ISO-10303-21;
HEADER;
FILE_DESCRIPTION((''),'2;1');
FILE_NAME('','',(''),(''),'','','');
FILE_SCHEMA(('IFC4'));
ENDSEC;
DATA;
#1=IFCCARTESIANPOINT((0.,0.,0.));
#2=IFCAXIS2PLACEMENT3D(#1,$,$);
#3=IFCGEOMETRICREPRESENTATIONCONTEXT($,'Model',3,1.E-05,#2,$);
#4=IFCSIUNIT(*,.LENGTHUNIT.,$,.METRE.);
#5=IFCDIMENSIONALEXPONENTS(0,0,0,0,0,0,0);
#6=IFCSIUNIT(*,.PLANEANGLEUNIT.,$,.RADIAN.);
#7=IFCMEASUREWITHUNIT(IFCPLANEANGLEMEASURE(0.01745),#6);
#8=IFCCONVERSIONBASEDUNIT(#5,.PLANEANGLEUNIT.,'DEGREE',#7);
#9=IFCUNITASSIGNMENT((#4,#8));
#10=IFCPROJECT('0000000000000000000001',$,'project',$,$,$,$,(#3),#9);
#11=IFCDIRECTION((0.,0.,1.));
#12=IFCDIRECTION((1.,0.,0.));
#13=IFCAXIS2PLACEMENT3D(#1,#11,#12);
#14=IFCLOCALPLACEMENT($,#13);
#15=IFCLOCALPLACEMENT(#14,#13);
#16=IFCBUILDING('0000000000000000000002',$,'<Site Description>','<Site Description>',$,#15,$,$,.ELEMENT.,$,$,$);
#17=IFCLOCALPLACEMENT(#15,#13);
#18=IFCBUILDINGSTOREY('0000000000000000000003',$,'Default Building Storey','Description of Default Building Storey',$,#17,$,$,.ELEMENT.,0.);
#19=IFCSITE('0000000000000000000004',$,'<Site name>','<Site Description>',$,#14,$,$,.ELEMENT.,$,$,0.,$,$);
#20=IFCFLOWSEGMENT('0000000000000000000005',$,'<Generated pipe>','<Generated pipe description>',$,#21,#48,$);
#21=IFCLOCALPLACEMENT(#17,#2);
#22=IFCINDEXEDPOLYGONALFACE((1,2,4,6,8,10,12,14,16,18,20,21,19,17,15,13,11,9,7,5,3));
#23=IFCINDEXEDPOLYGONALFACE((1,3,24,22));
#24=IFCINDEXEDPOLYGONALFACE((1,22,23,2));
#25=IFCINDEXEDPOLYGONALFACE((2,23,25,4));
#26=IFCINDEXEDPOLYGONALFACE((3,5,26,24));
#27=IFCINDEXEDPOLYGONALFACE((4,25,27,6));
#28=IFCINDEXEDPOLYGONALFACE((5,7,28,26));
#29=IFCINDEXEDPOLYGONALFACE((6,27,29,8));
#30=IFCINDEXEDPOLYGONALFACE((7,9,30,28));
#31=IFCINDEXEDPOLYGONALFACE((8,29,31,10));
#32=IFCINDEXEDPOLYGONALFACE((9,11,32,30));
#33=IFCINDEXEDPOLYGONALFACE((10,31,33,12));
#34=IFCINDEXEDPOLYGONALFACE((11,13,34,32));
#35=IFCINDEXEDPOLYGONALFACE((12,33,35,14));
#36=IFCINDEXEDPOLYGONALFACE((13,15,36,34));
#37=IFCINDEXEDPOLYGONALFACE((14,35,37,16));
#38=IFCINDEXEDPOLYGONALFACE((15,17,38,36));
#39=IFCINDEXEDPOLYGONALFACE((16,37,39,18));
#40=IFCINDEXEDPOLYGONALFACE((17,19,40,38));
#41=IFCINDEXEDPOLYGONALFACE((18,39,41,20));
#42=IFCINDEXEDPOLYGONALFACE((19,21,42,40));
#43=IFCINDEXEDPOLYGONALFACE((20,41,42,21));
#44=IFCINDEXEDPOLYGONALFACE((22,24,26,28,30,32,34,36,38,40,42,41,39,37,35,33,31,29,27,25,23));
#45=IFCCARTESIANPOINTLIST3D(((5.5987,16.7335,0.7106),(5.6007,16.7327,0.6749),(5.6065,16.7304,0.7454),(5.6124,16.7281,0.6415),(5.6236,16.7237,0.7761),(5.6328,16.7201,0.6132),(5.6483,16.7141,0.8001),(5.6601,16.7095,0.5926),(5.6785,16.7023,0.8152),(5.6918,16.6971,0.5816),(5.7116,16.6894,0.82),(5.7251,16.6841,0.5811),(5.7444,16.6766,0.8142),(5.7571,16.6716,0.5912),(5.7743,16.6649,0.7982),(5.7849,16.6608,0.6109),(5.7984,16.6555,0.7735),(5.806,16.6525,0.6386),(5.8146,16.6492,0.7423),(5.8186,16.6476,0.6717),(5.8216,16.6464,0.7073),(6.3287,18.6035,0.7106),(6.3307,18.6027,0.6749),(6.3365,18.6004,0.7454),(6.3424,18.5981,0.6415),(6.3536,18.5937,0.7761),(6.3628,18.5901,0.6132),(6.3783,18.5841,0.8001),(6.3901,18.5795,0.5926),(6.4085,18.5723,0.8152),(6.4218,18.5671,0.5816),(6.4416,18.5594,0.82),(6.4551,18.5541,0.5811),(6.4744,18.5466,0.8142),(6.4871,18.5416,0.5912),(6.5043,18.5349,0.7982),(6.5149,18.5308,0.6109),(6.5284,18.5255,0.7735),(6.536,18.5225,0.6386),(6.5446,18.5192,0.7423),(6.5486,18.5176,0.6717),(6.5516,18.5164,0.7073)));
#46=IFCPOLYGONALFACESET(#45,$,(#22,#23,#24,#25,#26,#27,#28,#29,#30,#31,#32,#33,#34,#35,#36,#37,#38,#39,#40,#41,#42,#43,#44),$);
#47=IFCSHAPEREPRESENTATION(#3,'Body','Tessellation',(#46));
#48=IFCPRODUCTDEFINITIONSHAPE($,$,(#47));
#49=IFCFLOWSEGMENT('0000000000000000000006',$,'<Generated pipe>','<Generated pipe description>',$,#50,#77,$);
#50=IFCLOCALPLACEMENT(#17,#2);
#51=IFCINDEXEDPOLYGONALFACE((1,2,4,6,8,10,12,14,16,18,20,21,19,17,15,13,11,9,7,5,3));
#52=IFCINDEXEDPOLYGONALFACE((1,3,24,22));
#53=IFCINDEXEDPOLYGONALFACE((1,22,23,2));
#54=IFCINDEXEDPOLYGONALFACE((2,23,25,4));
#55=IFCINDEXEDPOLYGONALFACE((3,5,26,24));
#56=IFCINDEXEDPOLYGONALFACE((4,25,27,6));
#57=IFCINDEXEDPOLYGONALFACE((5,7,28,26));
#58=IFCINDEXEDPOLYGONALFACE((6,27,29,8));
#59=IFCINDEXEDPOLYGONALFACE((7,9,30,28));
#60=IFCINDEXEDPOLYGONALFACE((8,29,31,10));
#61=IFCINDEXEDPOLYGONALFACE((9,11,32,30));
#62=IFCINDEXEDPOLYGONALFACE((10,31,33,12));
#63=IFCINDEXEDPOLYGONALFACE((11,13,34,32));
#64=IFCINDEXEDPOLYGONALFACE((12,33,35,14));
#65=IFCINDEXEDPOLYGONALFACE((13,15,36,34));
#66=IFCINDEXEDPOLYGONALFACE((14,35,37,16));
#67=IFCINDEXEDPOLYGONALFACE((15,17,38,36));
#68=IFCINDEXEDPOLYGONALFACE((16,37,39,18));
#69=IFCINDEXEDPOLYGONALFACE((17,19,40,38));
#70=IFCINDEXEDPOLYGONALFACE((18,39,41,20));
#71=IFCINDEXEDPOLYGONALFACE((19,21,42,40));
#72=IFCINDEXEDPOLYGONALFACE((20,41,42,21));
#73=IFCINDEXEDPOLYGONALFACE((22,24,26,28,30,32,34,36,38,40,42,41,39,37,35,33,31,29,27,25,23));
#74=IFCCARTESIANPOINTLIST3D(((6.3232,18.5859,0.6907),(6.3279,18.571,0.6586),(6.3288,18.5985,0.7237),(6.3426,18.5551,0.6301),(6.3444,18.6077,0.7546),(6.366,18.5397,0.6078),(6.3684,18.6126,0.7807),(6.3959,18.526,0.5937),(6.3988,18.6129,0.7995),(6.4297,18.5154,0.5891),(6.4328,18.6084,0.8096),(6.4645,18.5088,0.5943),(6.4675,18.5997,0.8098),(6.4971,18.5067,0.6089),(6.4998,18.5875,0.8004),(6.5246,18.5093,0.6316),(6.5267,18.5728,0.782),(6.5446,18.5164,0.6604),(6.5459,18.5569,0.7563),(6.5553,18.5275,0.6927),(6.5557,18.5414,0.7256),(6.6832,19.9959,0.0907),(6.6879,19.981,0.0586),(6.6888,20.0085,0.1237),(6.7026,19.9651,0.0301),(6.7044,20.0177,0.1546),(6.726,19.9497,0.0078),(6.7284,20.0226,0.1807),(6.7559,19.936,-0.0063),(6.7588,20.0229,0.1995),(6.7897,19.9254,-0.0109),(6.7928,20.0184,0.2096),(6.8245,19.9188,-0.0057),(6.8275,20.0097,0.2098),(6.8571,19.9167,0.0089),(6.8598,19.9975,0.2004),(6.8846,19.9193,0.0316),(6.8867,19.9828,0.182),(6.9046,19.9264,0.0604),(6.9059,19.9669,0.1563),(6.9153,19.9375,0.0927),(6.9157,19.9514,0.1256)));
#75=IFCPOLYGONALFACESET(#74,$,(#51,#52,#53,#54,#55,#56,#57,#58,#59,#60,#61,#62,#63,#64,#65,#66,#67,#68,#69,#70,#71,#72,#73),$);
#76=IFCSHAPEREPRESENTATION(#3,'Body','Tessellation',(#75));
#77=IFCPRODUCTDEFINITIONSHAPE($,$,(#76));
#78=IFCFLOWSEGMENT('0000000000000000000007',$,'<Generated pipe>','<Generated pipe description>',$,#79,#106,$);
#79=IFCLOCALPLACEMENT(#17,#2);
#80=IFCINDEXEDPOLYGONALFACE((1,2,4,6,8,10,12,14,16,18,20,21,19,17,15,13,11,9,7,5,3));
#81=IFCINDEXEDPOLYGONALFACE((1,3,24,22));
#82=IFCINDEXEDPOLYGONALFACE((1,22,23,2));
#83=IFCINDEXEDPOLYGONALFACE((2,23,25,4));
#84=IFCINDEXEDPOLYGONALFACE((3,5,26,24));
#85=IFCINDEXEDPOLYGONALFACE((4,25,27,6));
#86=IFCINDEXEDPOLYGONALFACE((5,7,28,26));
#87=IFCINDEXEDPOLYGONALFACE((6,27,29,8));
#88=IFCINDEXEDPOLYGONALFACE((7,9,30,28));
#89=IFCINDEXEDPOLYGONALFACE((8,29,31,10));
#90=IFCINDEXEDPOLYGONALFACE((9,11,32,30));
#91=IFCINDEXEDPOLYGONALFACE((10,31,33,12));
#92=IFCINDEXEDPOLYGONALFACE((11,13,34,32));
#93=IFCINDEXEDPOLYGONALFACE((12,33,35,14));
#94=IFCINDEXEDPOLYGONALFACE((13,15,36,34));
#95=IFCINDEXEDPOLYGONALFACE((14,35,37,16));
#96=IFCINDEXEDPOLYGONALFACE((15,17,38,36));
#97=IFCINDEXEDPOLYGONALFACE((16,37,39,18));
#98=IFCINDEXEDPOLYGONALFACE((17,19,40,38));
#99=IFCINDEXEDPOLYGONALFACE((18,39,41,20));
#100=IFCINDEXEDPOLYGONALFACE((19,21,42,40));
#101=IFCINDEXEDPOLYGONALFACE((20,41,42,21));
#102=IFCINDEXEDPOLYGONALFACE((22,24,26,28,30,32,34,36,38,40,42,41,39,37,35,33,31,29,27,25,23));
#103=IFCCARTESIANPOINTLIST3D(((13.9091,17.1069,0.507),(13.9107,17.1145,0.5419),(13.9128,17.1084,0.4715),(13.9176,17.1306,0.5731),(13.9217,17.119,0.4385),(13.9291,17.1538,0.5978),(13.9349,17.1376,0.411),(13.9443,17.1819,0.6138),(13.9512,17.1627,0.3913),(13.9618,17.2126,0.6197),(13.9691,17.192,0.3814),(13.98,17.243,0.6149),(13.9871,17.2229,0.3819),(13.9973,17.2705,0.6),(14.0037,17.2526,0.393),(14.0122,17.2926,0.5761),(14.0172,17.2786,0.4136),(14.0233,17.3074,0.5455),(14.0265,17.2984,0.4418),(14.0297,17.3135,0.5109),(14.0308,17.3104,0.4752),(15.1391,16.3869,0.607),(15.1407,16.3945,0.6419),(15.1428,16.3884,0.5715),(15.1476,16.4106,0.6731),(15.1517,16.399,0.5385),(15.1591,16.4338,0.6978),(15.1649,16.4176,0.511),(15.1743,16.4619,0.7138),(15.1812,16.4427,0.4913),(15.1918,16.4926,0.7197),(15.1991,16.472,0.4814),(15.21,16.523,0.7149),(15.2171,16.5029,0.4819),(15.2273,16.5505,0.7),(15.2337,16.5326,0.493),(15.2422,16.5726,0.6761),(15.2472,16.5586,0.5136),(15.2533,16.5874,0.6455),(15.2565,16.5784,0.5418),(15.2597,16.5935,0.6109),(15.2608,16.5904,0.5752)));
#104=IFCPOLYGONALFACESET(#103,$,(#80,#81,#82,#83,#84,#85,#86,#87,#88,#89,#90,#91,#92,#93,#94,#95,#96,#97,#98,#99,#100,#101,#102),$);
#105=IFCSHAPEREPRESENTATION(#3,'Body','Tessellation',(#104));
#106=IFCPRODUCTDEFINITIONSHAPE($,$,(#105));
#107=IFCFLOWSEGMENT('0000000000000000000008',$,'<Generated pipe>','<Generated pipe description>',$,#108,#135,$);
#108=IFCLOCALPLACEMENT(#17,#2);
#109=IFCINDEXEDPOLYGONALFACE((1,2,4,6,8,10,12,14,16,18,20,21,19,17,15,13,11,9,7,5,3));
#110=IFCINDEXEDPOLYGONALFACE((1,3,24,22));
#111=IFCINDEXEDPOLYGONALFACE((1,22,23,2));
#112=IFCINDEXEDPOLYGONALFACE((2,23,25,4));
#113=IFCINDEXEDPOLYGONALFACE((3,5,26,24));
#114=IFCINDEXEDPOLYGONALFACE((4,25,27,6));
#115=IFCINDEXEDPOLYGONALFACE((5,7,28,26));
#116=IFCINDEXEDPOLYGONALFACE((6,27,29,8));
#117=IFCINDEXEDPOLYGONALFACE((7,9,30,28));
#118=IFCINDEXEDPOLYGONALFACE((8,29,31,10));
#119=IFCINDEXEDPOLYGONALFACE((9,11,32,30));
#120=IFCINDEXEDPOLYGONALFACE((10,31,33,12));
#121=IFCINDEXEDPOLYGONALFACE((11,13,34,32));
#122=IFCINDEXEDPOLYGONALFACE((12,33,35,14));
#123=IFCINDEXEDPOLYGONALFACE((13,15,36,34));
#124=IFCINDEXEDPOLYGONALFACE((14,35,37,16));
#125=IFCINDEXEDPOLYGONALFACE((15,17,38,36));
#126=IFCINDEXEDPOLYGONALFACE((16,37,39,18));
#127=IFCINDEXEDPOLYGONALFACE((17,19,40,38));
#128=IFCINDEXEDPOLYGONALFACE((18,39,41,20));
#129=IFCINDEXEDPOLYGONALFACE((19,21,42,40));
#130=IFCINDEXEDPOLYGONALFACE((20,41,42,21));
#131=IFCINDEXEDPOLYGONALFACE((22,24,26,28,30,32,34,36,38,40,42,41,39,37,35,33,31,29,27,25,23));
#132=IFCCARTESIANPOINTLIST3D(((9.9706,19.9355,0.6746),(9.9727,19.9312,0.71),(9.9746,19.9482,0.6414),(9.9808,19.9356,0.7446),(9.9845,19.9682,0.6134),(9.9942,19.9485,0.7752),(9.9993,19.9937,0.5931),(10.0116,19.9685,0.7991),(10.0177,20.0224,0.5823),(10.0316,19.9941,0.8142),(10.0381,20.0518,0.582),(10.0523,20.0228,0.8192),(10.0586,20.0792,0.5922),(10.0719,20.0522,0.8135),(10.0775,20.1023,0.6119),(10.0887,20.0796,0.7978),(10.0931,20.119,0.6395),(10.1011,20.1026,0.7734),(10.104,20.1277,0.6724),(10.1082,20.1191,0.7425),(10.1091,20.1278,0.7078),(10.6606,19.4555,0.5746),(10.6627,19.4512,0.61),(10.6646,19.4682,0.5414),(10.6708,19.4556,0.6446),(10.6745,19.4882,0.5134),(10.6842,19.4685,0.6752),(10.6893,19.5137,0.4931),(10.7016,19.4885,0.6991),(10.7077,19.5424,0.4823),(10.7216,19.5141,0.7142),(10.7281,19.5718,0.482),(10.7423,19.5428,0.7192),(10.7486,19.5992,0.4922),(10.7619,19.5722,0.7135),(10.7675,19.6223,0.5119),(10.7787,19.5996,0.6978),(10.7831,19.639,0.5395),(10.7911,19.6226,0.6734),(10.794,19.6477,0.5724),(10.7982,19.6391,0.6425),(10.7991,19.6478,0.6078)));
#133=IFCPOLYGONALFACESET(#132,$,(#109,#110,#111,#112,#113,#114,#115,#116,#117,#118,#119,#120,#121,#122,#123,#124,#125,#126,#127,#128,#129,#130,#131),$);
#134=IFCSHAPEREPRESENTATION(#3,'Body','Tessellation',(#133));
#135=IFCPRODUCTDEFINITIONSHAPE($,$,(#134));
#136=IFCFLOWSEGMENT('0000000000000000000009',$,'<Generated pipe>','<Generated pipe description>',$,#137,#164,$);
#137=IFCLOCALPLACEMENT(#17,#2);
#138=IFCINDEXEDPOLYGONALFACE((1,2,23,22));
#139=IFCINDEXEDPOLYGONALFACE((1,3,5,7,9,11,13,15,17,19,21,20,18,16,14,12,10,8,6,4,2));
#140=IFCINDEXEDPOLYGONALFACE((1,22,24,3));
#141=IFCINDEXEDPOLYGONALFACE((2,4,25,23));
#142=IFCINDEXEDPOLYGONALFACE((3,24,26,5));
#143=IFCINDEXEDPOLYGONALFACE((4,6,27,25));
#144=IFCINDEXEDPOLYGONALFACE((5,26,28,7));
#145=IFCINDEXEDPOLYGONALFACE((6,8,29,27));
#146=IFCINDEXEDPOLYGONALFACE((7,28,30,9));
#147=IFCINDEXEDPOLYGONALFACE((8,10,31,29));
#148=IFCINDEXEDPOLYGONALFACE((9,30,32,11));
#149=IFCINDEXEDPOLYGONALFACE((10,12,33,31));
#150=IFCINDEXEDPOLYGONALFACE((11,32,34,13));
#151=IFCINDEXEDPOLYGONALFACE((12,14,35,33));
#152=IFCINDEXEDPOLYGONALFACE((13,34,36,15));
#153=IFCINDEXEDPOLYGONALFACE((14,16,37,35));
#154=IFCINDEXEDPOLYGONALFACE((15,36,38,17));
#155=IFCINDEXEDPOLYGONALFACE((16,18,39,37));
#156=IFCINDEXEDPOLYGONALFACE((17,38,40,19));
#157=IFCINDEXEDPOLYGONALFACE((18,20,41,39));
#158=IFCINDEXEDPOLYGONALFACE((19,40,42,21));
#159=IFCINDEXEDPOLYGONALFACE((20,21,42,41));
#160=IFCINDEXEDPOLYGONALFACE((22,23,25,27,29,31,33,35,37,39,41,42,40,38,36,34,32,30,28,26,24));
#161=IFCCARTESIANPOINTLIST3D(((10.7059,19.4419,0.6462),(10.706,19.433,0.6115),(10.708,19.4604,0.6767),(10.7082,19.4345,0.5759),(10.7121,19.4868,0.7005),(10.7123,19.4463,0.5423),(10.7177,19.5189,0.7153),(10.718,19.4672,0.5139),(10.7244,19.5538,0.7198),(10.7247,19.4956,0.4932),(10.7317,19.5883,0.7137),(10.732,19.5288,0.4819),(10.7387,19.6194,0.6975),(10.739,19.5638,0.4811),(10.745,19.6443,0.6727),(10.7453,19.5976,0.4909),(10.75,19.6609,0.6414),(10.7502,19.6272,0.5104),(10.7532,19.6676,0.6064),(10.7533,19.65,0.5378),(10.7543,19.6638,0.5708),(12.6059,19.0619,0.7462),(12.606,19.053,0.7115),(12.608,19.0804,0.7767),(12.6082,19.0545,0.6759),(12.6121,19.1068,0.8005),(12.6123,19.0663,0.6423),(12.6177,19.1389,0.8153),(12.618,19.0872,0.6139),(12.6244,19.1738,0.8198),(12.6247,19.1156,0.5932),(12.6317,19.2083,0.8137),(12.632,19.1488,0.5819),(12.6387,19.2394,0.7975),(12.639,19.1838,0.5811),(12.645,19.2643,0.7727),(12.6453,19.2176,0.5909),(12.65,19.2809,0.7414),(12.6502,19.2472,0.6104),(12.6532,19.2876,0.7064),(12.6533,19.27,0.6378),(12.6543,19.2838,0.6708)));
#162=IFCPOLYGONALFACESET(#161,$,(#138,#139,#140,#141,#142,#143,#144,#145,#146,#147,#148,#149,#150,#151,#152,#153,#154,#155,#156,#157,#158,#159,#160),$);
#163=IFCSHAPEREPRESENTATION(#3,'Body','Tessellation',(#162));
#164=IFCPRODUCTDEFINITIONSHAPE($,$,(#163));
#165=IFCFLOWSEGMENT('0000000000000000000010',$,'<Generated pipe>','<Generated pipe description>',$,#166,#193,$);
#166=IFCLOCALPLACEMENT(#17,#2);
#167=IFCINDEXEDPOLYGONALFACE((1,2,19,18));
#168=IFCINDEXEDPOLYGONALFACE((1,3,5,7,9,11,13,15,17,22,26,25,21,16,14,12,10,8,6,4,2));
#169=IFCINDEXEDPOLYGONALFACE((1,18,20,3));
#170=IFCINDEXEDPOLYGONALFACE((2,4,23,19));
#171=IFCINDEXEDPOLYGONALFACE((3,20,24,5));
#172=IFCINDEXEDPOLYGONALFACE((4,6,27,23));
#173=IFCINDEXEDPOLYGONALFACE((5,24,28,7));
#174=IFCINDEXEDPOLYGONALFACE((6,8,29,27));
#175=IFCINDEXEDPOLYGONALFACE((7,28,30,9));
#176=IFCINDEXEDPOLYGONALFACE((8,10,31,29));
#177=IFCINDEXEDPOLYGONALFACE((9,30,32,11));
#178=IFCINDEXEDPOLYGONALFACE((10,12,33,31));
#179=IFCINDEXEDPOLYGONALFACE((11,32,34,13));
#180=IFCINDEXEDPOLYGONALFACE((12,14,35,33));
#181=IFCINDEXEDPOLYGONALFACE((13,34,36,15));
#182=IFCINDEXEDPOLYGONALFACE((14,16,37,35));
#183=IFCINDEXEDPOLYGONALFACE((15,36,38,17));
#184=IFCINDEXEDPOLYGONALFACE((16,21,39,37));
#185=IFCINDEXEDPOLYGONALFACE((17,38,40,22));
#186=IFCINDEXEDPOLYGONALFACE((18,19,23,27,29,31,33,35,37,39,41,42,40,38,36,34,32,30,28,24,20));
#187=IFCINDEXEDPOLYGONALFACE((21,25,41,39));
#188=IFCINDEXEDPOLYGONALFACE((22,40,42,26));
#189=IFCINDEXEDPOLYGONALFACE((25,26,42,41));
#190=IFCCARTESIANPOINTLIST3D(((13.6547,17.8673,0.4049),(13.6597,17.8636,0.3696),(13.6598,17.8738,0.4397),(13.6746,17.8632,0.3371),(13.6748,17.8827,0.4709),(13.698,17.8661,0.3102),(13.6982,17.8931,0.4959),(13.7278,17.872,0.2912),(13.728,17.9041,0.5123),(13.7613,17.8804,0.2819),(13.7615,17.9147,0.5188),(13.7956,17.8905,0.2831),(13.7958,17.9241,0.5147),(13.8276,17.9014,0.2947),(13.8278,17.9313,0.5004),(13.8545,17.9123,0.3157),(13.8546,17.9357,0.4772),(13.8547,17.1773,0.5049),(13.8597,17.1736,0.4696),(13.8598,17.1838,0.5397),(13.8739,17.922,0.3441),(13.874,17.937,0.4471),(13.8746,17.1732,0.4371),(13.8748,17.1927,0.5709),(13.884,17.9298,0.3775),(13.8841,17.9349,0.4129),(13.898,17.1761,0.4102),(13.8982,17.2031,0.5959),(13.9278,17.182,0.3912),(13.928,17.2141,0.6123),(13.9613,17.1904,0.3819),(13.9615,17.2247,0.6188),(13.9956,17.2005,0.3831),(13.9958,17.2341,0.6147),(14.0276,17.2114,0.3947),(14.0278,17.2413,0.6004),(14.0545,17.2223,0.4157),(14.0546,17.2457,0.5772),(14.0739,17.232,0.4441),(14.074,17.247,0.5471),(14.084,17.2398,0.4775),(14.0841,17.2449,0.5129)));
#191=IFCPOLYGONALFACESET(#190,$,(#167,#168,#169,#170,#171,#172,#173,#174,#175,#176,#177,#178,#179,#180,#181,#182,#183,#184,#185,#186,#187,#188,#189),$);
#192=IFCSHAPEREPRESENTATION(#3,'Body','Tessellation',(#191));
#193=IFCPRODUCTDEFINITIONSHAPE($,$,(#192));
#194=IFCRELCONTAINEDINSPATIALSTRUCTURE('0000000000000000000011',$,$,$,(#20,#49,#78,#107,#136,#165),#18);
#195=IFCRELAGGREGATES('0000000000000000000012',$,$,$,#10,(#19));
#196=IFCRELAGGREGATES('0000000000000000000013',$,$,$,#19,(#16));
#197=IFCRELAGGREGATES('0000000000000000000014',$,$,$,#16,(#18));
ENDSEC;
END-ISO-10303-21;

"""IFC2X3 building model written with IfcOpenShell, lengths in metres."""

from ifc_helpers import new_model, entity, si_unit, converted_unit, frame, origin, origin_with_axes, origin_2d_with_axis, place, context, project, spatial, circle, extrude, element, save


model = new_model("IFC2X3")

# Units and contexts
model_context = context("Model", 3, precision=1e-05, world=origin())
ifc_project = project(units=[si_unit("LENGTHUNIT", "METRE"), converted_unit("PLANEANGLEUNIT", "DEGREE", entity("IfcPlaneAngleMeasure", 0.01745), si_unit("PLANEANGLEUNIT", "RADIAN"), dimensions=[0, 0, 0, 0, 0, 0, 0])], contexts=[model_context])

# Site, building, storey
site_placement = place(None, origin_with_axes())
site = spatial("IfcSite", under=ifc_project, at=site_placement, Name="<Site name>", Description="<Site Description>", CompositionType="ELEMENT", RefElevation=0.0)
building_placement = place(site_placement, origin_with_axes())
building = spatial("IfcBuilding", under=site, at=building_placement, Name="<Site Description>", Description="<Site Description>", CompositionType="ELEMENT")
storey_placement = place(building_placement, origin_with_axes())
storey = spatial("IfcBuildingStorey", under=building, at=storey_placement, Name="Default Building Storey", Description="Description of Default Building Storey", CompositionType="ELEMENT", Elevation=0.0)

# Flow segments
flow_segment_1_placement = place(storey_placement, frame((5.71, 16.69, 0.7), z_axis=(0.363648, 0.931536, 0.0), x_axis=(0.535422, -0.209015, 0.818313)))
element("IfcFlowSegment", 1, at=flow_segment_1_placement, inside=storey, Name="<Generated pipe>", Description="<Generated pipe description>", context=model_context, shape_type="SweptSolid", body=[
    extrude(circle(Radius=0.12, at=origin_2d_with_axis()), origin_with_axes(), (0.0, 0.0, 1.0), 2.0074),
])
flow_segment_2_placement = place(storey_placement, frame((6.44, 18.56, 0.7), z_axis=(0.228706, 0.895766, -0.381177), x_axis=(0.497959, 0.228807, 0.836471)))
element("IfcFlowSegment", 2, at=flow_segment_2_placement, inside=storey, Name="<Generated pipe>", Description="<Generated pipe description>", context=model_context, shape_type="SweptSolid", body=[
    extrude(circle(Radius=0.12, at=origin_2d_with_axis()), origin_with_axes(), (0.0, 0.0, 1.0), 1.5741),
])
flow_segment_3_placement = place(storey_placement, frame((13.97, 17.21, 0.5), z_axis=(0.860898, -0.50394, 0.069992), x_axis=(0.444285, 0.811658, 0.379239)))
element("IfcFlowSegment", 3, at=flow_segment_3_placement, inside=storey, Name="<Generated pipe>", Description="<Generated pipe description>", context=model_context, shape_type="SweptSolid", body=[
    extrude(circle(Radius=0.12, at=origin_2d_with_axis()), origin_with_axes(), (0.0, 0.0, 1.0), 1.4287),
])
flow_segment_4_placement = place(storey_placement, frame((10.04, 20.03, 0.7), z_axis=(0.815156, -0.567065, -0.118139), x_axis=(0.4057, 0.413362, 0.815193)))
element("IfcFlowSegment", 4, at=flow_segment_4_placement, inside=storey, Name="<Generated pipe>", Description="<Generated pipe description>", context=model_context, shape_type="SweptSolid", body=[
    extrude(circle(Radius=0.12, at=origin_2d_with_axis()), origin_with_axes(), (0.0, 0.0, 1.0), 0.8465),
])
flow_segment_5_placement = place(storey_placement, frame((10.73, 19.55, 0.6), z_axis=(0.979277, -0.195855, 0.051541), x_axis=(0.013884, 0.318817, 0.947715)))
element("IfcFlowSegment", 5, at=flow_segment_5_placement, inside=storey, Name="<Generated pipe>", Description="<Generated pipe description>", context=model_context, shape_type="SweptSolid", body=[
    extrude(circle(Radius=0.12, at=origin_2d_with_axis()), origin_with_axes(), (0.0, 0.0, 1.0), 1.9402),
])
flow_segment_6_placement = place(storey_placement, frame((13.77, 17.9, 0.4), z_axis=(0.275738, -0.951294, 0.137869), x_axis=(0.705279, 0.297676, 0.643406)))
element("IfcFlowSegment", 6, at=flow_segment_6_placement, inside=storey, Name="<Generated pipe>", Description="<Generated pipe description>", context=model_context, shape_type="SweptSolid", body=[
    extrude(circle(Radius=0.12, at=origin_2d_with_axis()), origin_with_axes(), (0.0, 0.0, 1.0), 0.7253),
])

save(model, "model.ifc")
